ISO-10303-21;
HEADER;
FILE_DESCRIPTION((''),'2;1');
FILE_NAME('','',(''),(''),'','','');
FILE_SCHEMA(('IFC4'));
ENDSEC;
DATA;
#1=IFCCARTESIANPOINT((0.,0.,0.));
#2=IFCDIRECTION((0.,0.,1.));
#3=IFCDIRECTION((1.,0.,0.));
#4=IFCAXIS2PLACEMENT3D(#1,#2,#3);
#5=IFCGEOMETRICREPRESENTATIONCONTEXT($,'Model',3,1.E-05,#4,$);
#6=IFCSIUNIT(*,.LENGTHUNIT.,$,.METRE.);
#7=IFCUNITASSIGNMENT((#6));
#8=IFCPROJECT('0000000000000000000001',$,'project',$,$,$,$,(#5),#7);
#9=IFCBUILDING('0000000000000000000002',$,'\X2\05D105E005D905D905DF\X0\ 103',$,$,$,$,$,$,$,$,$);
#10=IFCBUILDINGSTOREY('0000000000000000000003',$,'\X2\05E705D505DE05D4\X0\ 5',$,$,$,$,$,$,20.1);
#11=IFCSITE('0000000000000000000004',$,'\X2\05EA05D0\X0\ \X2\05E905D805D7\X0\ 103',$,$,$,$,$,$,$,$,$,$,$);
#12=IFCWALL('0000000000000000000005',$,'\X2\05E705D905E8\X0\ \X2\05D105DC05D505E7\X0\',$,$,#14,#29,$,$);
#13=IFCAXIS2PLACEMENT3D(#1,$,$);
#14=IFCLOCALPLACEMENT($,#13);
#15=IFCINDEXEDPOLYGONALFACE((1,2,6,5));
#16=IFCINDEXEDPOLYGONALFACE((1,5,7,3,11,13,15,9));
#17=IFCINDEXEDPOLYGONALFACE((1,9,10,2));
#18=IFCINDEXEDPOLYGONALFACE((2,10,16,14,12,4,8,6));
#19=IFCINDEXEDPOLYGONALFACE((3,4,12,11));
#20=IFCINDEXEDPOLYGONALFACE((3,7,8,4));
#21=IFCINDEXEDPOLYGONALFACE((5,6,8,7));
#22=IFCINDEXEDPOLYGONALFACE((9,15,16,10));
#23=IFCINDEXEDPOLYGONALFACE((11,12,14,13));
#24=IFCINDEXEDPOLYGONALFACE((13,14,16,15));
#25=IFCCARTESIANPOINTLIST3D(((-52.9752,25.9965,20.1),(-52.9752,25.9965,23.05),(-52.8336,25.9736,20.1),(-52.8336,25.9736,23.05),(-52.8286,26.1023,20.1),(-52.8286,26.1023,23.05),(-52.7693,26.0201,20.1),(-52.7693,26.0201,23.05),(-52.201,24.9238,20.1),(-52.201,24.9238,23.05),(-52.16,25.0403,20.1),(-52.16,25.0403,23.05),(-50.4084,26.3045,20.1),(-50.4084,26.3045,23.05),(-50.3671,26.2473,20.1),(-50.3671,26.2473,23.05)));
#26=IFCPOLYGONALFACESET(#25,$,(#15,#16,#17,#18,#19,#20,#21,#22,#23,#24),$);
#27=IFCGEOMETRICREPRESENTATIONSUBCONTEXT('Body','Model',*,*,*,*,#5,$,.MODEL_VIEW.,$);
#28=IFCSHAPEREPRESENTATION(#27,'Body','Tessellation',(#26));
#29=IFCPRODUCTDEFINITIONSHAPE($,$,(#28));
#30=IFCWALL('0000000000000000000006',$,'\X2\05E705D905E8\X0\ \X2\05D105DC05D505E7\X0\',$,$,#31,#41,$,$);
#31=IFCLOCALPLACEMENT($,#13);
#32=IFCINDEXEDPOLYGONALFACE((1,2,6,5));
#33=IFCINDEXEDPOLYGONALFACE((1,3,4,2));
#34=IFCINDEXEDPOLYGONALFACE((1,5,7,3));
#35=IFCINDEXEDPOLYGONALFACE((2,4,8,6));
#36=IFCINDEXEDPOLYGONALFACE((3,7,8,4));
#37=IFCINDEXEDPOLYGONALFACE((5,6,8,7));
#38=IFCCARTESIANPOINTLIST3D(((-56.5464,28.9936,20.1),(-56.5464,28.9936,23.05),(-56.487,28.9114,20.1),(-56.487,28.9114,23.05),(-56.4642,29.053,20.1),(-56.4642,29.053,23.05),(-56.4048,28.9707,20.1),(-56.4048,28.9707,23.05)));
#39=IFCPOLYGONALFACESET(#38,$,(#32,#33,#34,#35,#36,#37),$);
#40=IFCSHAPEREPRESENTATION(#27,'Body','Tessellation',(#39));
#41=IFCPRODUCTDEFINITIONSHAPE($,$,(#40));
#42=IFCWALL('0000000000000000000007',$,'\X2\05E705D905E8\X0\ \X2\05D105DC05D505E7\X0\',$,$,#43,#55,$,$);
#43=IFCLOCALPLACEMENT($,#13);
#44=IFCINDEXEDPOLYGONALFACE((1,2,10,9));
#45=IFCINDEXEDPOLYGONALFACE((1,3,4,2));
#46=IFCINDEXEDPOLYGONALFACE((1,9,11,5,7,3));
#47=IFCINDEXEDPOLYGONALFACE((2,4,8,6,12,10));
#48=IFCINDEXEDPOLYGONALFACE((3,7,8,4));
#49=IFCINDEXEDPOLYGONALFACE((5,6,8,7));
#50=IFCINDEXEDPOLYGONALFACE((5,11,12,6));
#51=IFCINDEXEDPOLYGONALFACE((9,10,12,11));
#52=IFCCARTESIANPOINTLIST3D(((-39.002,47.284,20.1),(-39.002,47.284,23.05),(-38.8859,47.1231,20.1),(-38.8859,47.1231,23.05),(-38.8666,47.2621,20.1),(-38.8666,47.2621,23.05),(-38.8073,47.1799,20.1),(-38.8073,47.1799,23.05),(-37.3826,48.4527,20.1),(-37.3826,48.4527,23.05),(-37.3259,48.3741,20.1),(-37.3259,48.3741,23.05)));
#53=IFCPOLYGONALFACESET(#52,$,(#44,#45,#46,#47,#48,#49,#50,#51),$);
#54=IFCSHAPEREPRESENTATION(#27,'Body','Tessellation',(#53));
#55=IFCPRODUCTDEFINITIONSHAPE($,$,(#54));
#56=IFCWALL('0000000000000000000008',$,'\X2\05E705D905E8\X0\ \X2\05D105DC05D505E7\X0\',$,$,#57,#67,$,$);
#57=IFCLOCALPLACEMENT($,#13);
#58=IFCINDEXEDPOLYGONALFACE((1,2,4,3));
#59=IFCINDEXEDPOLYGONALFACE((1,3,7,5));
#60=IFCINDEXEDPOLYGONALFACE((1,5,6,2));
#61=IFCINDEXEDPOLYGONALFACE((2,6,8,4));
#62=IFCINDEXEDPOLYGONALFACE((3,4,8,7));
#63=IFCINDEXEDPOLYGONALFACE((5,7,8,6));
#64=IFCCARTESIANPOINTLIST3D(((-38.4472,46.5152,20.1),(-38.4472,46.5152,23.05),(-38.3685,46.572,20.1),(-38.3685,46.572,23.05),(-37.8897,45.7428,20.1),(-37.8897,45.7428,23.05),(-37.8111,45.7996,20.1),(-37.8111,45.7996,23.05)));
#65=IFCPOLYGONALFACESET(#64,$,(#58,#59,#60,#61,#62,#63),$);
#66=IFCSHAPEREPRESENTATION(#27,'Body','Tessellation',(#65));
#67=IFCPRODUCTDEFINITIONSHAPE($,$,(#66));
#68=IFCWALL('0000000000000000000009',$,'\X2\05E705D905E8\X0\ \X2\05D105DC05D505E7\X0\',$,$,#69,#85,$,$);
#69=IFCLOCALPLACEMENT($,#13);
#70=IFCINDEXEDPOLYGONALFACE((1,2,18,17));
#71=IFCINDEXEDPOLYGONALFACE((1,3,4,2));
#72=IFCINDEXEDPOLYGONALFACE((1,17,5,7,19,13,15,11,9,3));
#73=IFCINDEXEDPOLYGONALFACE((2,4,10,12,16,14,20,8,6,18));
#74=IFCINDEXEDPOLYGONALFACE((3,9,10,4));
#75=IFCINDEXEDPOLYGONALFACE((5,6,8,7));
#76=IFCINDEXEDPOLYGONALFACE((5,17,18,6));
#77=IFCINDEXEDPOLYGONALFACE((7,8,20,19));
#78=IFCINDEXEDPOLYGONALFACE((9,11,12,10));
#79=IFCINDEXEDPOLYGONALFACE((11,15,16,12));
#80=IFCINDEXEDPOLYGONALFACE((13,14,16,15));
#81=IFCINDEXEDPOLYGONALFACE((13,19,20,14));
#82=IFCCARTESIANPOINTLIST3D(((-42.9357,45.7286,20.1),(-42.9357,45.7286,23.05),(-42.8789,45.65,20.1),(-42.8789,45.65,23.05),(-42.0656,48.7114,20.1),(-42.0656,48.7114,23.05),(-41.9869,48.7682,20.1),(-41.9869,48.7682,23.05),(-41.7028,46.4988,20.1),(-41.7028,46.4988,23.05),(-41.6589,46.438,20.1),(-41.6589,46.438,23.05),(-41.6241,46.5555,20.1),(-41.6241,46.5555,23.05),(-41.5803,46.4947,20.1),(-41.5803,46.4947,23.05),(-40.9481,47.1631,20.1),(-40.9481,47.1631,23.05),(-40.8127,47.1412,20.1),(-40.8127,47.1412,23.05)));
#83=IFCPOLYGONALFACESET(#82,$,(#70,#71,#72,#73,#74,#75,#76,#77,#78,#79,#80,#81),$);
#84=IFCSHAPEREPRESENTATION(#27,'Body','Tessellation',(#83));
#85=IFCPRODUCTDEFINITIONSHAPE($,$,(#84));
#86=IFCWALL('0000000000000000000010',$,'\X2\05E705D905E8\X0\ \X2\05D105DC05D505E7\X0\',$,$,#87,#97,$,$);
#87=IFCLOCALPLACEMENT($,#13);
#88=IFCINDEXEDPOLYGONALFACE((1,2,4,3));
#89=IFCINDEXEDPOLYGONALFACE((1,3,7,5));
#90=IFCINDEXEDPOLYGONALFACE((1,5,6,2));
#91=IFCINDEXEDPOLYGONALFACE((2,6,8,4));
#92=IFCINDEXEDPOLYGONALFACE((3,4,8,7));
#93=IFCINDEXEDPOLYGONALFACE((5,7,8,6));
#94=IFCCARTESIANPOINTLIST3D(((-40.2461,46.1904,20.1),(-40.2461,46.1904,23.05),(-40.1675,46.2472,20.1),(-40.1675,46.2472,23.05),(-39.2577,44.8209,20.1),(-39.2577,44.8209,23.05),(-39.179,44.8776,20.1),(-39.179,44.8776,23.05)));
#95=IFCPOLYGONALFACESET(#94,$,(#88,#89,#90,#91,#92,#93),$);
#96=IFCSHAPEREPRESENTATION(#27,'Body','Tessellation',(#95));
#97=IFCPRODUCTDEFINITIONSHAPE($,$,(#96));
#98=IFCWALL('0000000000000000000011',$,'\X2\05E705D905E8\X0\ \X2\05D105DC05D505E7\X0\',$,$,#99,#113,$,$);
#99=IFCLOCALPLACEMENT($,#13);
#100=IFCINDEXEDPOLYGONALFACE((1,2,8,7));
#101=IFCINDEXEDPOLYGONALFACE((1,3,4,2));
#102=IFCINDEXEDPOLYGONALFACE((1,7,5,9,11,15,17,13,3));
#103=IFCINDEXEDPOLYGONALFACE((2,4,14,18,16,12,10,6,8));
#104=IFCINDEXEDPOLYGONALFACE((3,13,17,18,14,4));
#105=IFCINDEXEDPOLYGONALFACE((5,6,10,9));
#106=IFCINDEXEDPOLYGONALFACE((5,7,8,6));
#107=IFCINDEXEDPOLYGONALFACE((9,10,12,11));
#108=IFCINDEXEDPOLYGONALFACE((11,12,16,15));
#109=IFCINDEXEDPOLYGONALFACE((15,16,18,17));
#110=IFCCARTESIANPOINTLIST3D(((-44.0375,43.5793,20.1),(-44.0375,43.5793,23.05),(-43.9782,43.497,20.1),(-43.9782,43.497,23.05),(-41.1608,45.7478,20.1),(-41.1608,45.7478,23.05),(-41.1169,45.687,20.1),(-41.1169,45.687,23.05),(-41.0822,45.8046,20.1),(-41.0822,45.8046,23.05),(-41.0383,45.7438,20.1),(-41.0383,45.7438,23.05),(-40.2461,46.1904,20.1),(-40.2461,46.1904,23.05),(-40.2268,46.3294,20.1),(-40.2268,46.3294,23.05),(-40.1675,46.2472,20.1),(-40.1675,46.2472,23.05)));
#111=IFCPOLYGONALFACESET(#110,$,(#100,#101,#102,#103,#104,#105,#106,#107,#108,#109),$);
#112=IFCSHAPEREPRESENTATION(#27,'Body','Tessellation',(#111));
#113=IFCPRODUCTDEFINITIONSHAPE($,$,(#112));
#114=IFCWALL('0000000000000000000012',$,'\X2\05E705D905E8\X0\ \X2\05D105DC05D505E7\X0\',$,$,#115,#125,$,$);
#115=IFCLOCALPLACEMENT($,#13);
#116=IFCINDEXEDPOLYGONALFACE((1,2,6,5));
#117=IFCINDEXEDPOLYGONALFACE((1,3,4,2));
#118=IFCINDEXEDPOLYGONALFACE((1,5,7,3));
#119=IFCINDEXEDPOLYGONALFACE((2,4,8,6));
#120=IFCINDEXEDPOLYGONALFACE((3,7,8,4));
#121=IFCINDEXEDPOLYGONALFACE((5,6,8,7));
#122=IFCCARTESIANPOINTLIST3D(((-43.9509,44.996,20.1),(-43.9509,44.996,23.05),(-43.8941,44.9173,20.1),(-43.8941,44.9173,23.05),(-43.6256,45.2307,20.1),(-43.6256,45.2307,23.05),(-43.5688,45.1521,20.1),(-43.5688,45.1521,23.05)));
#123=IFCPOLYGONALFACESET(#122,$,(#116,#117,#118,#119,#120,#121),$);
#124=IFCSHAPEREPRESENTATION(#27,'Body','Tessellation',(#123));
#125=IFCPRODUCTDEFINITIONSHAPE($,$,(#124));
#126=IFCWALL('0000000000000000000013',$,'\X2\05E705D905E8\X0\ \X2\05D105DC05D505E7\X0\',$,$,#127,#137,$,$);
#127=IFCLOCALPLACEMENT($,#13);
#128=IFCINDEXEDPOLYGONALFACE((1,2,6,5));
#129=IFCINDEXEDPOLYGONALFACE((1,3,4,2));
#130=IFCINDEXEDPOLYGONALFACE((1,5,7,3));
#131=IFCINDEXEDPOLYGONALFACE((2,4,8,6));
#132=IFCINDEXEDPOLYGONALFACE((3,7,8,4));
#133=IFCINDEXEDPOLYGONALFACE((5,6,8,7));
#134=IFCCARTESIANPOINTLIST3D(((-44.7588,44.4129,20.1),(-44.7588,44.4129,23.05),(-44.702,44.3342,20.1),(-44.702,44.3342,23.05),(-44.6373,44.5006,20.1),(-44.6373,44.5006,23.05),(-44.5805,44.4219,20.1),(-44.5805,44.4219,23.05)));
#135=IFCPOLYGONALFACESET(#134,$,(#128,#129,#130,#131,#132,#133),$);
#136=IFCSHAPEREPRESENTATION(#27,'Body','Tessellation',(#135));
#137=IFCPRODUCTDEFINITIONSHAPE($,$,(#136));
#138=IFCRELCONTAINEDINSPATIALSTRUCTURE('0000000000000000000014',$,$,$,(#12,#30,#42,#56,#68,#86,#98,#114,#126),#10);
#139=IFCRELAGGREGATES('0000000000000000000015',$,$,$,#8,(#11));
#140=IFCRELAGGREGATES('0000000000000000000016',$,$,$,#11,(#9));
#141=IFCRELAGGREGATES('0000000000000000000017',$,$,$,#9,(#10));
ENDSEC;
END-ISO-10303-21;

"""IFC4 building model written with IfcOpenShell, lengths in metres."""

from ifc_helpers import new_model, si_unit, frame, origin_with_axes, context, subcontext, project, spatial, polyline, outline, extrude, element, save


model = new_model("IFC4")

# Units and contexts
model_context = context("Model", 3, precision=1e-05, world=origin_with_axes())
body_context = subcontext(model_context, "Body", "Model", "MODEL_VIEW")
ifc_project = project(units=[si_unit("LENGTHUNIT", "METRE")], contexts=[model_context])

# Site, building, storey
site = spatial("IfcSite", under=ifc_project, Name="תא שטח 103")
building = spatial("IfcBuilding", under=site, Name="בניין 103")
storey = spatial("IfcBuildingStorey", under=building, Name="קומה 5", Elevation=20.1)

# Walls
element("IfcWall", 1, inside=storey, Name="קיר בלוק", context=body_context, shape_type="SweptSolid", body=[
    extrude(outline(polyline([(-50.3671, 26.2473), (-52.201, 24.9238), (-52.9752, 25.9965), (-52.8286, 26.1023), (-52.7693, 26.0201), (-52.8336, 25.9736), (-52.16, 25.0403), (-50.4084, 26.3045), (-50.3671, 26.2473)])), frame((0.0, 0.0, 20.1)), (0.0, 0.0, 1.0), 2.95),
])
element("IfcWall", 2, inside=storey, Name="קיר בלוק", context=body_context, shape_type="SweptSolid", body=[
    extrude(outline(polyline([(-56.487, 28.9114), (-56.5464, 28.9936), (-56.4642, 29.053), (-56.4048, 28.9707), (-56.487, 28.9114)])), frame((0.0, 0.0, 20.1)), (0.0, 0.0, 1.0), 2.95),
])
element("IfcWall", 3, inside=storey, Name="קיר בלוק", context=body_context, shape_type="SweptSolid", body=[
    extrude(outline(polyline([(-38.8859, 47.1231), (-39.002, 47.284), (-37.3826, 48.4527), (-37.3259, 48.3741), (-38.8666, 47.2621), (-38.8073, 47.1799), (-38.8859, 47.1231)])), frame((0.0, 0.0, 20.1)), (0.0, 0.0, 1.0), 2.95),
])
element("IfcWall", 4, inside=storey, Name="קיר בלוק", context=body_context, shape_type="SweptSolid", body=[
    extrude(outline(polyline([(-37.8111, 45.7996), (-37.8897, 45.7428), (-38.4472, 46.5152), (-38.3685, 46.572), (-37.8111, 45.7996)])), frame((0.0, 0.0, 20.1)), (0.0, 0.0, 1.0), 2.95),
])
element("IfcWall", 5, inside=storey, Name="קיר בלוק", context=body_context, shape_type="SweptSolid", body=[
    extrude(outline(polyline([(-40.8127, 47.1412), (-41.6241, 46.5555), (-41.5803, 46.4947), (-41.6589, 46.438), (-41.7028, 46.4988), (-42.8789, 45.65), (-42.9357, 45.7286), (-40.9481, 47.1631), (-42.0656, 48.7114), (-41.9869, 48.7682), (-40.8127, 47.1412)])), frame((0.0, 0.0, 20.1)), (0.0, 0.0, 1.0), 2.95),
])
element("IfcWall", 6, inside=storey, Name="קיר בלוק", context=body_context, shape_type="SweptSolid", body=[
    extrude(outline(polyline([(-39.2577, 44.8209), (-40.2461, 46.1904), (-40.1675, 46.2472), (-39.179, 44.8776), (-39.2577, 44.8209)])), frame((0.0, 0.0, 20.1)), (0.0, 0.0, 1.0), 2.95),
])
element("IfcWall", 7, inside=storey, Name="קיר בלוק", context=body_context, shape_type="SweptSolid", body=[
    extrude(outline(polyline([(-40.2461, 46.1904), (-43.9782, 43.497), (-44.0375, 43.5793), (-41.1169, 45.687), (-41.1608, 45.7478), (-41.0822, 45.8046), (-41.0383, 45.7438), (-40.2268, 46.3294), (-40.1675, 46.2472), (-40.2461, 46.1904)])), frame((0.0, 0.0, 20.1)), (0.0, 0.0, 1.0), 2.95),
])
element("IfcWall", 8, inside=storey, Name="קיר בלוק", context=body_context, shape_type="SweptSolid", body=[
    extrude(outline(polyline([(-43.6256, 45.2307), (-43.5688, 45.1521), (-43.8941, 44.9173), (-43.9509, 44.996), (-43.6256, 45.2307)])), frame((0.0, 0.0, 20.1)), (0.0, 0.0, 1.0), 2.95),
])
element("IfcWall", 9, inside=storey, Name="קיר בלוק", context=body_context, shape_type="SweptSolid", body=[
    extrude(outline(polyline([(-44.5805, 44.4219), (-44.702, 44.3342), (-44.7588, 44.4129), (-44.6373, 44.5006), (-44.5805, 44.4219)])), frame((0.0, 0.0, 20.1)), (0.0, 0.0, 1.0), 2.95),
])

save(model, "model.ifc")
